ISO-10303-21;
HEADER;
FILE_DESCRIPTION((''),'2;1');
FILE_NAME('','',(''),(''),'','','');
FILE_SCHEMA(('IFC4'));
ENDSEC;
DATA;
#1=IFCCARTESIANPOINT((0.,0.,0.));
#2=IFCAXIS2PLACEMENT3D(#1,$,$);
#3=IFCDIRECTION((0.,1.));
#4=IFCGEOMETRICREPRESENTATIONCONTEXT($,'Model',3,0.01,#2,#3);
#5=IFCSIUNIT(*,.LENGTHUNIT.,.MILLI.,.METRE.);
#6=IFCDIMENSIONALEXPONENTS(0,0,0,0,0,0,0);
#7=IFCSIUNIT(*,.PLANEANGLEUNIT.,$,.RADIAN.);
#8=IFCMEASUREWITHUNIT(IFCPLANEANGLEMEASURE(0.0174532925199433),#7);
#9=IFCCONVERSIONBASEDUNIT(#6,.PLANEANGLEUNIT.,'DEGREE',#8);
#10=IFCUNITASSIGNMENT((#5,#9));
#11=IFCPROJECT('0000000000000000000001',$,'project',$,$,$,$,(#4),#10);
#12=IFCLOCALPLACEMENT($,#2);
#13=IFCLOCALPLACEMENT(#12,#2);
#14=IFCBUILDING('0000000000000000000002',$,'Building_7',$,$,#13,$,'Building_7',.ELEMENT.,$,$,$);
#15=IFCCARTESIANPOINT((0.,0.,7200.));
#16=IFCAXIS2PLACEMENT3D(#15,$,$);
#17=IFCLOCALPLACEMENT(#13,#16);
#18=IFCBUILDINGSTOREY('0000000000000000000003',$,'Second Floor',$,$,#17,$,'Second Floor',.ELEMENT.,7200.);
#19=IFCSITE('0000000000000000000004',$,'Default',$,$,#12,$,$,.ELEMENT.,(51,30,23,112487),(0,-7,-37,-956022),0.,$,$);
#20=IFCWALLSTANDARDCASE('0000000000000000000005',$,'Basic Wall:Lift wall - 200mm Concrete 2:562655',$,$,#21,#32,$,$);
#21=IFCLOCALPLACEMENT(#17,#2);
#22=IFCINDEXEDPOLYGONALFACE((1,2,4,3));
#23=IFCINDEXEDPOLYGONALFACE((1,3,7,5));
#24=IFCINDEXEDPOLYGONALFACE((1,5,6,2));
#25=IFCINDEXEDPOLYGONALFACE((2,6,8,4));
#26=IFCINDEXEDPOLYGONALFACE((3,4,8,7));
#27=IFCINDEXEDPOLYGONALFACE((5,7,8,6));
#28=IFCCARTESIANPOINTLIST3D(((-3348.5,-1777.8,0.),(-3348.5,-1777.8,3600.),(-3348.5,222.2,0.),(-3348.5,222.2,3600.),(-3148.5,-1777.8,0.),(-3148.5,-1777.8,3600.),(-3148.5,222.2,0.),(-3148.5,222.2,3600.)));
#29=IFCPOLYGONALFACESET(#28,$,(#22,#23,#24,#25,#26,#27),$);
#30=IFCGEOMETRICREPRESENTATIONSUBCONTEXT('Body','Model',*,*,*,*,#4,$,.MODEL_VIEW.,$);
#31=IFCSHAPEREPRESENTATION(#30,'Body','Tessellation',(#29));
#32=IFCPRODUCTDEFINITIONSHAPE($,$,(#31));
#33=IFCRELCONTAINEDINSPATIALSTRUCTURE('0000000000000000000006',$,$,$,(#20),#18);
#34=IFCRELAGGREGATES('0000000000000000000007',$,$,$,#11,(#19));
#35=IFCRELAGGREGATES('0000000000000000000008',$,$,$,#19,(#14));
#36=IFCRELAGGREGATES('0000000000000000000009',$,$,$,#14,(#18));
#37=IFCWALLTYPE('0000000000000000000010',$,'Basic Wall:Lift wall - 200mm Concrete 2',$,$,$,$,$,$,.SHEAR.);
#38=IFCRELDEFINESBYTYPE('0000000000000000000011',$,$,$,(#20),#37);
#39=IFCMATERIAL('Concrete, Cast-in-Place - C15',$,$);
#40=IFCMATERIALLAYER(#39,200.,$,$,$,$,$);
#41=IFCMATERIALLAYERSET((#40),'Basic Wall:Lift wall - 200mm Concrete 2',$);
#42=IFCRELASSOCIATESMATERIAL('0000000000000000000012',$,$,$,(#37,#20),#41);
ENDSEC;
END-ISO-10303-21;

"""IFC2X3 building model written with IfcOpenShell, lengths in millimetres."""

from ifc_helpers import new_model, entity, si_unit, converted_unit, direction, frame, frame_2d, origin, place, context, subcontext, project, spatial, rectangle, extrude, material, layer, layer_set, layer_usage, type_object, element, save


model = new_model("IFC2X3")

# Units and contexts
model_context = context("Model", 3, precision=0.01, world=origin(), true_north=direction((0.0, 1.0)))
body_context = subcontext(model_context, "Body", "Model", "MODEL_VIEW")
ifc_project = project(units=[si_unit("LENGTHUNIT", "METRE", prefix="MILLI"), converted_unit("PLANEANGLEUNIT", "DEGREE", entity("IfcPlaneAngleMeasure", 0.0174532925199433), si_unit("PLANEANGLEUNIT", "RADIAN"), dimensions=[0, 0, 0, 0, 0, 0, 0])], contexts=[model_context])

# Site, building, storey
site_placement = place(None, origin())
site = spatial("IfcSite", under=ifc_project, at=site_placement, Name="Default", CompositionType="ELEMENT", RefLatitude=(51, 30, 23, 112487), RefLongitude=(0, -7, -37, -956022), RefElevation=0.0)
building_placement = place(site_placement, origin())
building = spatial("IfcBuilding", under=site, at=building_placement, Name="Building_7", LongName="Building_7", CompositionType="ELEMENT")
storey_placement = place(building_placement, frame((0.0, 0.0, 7200.0)))
storey = spatial("IfcBuildingStorey", under=building, at=storey_placement, Name="Second Floor", LongName="Second Floor", CompositionType="ELEMENT", Elevation=7200.0)

# Shared definitions
ifc_material_1 = material(Name="Concrete, Cast-in-Place - C15")

# Wall
ifc_layer_1 = layer(ifc_material_1, 200.0)
ifc_layer_set_1 = layer_set([ifc_layer_1], Name="Basic Wall:Lift wall - 200mm Concrete 2")
ifc_layer_usage_1 = layer_usage(ifc_layer_set_1, "AXIS2", "NEGATIVE", 100.0)
wall_type_1 = type_object("IfcWallType", Name="Basic Wall:Lift wall - 200mm Concrete 2", PredefinedType="SHEAR", material=ifc_layer_set_1)
wall_1_placement = place(storey_placement, frame((-3248.5, 222.2, 0.0), z_axis=(0.0, 0.0, 1.0), x_axis=(0.0, -1.0, 0.0)))
element("IfcWallStandardCase", 1, at=wall_1_placement, inside=storey, type_object=wall_type_1, material=ifc_layer_usage_1, Name="Basic Wall:Lift wall - 200mm Concrete 2:562655", context=body_context, shape_type="SweptSolid", body=[
    extrude(rectangle(XDim=2000.0, YDim=200.0, at=frame_2d((1000.0, 0.0), x_axis=(-1.0, 0.0))), origin(), (0.0, 0.0, 1.0), 3600.0),
])

save(model, "model.ifc")
